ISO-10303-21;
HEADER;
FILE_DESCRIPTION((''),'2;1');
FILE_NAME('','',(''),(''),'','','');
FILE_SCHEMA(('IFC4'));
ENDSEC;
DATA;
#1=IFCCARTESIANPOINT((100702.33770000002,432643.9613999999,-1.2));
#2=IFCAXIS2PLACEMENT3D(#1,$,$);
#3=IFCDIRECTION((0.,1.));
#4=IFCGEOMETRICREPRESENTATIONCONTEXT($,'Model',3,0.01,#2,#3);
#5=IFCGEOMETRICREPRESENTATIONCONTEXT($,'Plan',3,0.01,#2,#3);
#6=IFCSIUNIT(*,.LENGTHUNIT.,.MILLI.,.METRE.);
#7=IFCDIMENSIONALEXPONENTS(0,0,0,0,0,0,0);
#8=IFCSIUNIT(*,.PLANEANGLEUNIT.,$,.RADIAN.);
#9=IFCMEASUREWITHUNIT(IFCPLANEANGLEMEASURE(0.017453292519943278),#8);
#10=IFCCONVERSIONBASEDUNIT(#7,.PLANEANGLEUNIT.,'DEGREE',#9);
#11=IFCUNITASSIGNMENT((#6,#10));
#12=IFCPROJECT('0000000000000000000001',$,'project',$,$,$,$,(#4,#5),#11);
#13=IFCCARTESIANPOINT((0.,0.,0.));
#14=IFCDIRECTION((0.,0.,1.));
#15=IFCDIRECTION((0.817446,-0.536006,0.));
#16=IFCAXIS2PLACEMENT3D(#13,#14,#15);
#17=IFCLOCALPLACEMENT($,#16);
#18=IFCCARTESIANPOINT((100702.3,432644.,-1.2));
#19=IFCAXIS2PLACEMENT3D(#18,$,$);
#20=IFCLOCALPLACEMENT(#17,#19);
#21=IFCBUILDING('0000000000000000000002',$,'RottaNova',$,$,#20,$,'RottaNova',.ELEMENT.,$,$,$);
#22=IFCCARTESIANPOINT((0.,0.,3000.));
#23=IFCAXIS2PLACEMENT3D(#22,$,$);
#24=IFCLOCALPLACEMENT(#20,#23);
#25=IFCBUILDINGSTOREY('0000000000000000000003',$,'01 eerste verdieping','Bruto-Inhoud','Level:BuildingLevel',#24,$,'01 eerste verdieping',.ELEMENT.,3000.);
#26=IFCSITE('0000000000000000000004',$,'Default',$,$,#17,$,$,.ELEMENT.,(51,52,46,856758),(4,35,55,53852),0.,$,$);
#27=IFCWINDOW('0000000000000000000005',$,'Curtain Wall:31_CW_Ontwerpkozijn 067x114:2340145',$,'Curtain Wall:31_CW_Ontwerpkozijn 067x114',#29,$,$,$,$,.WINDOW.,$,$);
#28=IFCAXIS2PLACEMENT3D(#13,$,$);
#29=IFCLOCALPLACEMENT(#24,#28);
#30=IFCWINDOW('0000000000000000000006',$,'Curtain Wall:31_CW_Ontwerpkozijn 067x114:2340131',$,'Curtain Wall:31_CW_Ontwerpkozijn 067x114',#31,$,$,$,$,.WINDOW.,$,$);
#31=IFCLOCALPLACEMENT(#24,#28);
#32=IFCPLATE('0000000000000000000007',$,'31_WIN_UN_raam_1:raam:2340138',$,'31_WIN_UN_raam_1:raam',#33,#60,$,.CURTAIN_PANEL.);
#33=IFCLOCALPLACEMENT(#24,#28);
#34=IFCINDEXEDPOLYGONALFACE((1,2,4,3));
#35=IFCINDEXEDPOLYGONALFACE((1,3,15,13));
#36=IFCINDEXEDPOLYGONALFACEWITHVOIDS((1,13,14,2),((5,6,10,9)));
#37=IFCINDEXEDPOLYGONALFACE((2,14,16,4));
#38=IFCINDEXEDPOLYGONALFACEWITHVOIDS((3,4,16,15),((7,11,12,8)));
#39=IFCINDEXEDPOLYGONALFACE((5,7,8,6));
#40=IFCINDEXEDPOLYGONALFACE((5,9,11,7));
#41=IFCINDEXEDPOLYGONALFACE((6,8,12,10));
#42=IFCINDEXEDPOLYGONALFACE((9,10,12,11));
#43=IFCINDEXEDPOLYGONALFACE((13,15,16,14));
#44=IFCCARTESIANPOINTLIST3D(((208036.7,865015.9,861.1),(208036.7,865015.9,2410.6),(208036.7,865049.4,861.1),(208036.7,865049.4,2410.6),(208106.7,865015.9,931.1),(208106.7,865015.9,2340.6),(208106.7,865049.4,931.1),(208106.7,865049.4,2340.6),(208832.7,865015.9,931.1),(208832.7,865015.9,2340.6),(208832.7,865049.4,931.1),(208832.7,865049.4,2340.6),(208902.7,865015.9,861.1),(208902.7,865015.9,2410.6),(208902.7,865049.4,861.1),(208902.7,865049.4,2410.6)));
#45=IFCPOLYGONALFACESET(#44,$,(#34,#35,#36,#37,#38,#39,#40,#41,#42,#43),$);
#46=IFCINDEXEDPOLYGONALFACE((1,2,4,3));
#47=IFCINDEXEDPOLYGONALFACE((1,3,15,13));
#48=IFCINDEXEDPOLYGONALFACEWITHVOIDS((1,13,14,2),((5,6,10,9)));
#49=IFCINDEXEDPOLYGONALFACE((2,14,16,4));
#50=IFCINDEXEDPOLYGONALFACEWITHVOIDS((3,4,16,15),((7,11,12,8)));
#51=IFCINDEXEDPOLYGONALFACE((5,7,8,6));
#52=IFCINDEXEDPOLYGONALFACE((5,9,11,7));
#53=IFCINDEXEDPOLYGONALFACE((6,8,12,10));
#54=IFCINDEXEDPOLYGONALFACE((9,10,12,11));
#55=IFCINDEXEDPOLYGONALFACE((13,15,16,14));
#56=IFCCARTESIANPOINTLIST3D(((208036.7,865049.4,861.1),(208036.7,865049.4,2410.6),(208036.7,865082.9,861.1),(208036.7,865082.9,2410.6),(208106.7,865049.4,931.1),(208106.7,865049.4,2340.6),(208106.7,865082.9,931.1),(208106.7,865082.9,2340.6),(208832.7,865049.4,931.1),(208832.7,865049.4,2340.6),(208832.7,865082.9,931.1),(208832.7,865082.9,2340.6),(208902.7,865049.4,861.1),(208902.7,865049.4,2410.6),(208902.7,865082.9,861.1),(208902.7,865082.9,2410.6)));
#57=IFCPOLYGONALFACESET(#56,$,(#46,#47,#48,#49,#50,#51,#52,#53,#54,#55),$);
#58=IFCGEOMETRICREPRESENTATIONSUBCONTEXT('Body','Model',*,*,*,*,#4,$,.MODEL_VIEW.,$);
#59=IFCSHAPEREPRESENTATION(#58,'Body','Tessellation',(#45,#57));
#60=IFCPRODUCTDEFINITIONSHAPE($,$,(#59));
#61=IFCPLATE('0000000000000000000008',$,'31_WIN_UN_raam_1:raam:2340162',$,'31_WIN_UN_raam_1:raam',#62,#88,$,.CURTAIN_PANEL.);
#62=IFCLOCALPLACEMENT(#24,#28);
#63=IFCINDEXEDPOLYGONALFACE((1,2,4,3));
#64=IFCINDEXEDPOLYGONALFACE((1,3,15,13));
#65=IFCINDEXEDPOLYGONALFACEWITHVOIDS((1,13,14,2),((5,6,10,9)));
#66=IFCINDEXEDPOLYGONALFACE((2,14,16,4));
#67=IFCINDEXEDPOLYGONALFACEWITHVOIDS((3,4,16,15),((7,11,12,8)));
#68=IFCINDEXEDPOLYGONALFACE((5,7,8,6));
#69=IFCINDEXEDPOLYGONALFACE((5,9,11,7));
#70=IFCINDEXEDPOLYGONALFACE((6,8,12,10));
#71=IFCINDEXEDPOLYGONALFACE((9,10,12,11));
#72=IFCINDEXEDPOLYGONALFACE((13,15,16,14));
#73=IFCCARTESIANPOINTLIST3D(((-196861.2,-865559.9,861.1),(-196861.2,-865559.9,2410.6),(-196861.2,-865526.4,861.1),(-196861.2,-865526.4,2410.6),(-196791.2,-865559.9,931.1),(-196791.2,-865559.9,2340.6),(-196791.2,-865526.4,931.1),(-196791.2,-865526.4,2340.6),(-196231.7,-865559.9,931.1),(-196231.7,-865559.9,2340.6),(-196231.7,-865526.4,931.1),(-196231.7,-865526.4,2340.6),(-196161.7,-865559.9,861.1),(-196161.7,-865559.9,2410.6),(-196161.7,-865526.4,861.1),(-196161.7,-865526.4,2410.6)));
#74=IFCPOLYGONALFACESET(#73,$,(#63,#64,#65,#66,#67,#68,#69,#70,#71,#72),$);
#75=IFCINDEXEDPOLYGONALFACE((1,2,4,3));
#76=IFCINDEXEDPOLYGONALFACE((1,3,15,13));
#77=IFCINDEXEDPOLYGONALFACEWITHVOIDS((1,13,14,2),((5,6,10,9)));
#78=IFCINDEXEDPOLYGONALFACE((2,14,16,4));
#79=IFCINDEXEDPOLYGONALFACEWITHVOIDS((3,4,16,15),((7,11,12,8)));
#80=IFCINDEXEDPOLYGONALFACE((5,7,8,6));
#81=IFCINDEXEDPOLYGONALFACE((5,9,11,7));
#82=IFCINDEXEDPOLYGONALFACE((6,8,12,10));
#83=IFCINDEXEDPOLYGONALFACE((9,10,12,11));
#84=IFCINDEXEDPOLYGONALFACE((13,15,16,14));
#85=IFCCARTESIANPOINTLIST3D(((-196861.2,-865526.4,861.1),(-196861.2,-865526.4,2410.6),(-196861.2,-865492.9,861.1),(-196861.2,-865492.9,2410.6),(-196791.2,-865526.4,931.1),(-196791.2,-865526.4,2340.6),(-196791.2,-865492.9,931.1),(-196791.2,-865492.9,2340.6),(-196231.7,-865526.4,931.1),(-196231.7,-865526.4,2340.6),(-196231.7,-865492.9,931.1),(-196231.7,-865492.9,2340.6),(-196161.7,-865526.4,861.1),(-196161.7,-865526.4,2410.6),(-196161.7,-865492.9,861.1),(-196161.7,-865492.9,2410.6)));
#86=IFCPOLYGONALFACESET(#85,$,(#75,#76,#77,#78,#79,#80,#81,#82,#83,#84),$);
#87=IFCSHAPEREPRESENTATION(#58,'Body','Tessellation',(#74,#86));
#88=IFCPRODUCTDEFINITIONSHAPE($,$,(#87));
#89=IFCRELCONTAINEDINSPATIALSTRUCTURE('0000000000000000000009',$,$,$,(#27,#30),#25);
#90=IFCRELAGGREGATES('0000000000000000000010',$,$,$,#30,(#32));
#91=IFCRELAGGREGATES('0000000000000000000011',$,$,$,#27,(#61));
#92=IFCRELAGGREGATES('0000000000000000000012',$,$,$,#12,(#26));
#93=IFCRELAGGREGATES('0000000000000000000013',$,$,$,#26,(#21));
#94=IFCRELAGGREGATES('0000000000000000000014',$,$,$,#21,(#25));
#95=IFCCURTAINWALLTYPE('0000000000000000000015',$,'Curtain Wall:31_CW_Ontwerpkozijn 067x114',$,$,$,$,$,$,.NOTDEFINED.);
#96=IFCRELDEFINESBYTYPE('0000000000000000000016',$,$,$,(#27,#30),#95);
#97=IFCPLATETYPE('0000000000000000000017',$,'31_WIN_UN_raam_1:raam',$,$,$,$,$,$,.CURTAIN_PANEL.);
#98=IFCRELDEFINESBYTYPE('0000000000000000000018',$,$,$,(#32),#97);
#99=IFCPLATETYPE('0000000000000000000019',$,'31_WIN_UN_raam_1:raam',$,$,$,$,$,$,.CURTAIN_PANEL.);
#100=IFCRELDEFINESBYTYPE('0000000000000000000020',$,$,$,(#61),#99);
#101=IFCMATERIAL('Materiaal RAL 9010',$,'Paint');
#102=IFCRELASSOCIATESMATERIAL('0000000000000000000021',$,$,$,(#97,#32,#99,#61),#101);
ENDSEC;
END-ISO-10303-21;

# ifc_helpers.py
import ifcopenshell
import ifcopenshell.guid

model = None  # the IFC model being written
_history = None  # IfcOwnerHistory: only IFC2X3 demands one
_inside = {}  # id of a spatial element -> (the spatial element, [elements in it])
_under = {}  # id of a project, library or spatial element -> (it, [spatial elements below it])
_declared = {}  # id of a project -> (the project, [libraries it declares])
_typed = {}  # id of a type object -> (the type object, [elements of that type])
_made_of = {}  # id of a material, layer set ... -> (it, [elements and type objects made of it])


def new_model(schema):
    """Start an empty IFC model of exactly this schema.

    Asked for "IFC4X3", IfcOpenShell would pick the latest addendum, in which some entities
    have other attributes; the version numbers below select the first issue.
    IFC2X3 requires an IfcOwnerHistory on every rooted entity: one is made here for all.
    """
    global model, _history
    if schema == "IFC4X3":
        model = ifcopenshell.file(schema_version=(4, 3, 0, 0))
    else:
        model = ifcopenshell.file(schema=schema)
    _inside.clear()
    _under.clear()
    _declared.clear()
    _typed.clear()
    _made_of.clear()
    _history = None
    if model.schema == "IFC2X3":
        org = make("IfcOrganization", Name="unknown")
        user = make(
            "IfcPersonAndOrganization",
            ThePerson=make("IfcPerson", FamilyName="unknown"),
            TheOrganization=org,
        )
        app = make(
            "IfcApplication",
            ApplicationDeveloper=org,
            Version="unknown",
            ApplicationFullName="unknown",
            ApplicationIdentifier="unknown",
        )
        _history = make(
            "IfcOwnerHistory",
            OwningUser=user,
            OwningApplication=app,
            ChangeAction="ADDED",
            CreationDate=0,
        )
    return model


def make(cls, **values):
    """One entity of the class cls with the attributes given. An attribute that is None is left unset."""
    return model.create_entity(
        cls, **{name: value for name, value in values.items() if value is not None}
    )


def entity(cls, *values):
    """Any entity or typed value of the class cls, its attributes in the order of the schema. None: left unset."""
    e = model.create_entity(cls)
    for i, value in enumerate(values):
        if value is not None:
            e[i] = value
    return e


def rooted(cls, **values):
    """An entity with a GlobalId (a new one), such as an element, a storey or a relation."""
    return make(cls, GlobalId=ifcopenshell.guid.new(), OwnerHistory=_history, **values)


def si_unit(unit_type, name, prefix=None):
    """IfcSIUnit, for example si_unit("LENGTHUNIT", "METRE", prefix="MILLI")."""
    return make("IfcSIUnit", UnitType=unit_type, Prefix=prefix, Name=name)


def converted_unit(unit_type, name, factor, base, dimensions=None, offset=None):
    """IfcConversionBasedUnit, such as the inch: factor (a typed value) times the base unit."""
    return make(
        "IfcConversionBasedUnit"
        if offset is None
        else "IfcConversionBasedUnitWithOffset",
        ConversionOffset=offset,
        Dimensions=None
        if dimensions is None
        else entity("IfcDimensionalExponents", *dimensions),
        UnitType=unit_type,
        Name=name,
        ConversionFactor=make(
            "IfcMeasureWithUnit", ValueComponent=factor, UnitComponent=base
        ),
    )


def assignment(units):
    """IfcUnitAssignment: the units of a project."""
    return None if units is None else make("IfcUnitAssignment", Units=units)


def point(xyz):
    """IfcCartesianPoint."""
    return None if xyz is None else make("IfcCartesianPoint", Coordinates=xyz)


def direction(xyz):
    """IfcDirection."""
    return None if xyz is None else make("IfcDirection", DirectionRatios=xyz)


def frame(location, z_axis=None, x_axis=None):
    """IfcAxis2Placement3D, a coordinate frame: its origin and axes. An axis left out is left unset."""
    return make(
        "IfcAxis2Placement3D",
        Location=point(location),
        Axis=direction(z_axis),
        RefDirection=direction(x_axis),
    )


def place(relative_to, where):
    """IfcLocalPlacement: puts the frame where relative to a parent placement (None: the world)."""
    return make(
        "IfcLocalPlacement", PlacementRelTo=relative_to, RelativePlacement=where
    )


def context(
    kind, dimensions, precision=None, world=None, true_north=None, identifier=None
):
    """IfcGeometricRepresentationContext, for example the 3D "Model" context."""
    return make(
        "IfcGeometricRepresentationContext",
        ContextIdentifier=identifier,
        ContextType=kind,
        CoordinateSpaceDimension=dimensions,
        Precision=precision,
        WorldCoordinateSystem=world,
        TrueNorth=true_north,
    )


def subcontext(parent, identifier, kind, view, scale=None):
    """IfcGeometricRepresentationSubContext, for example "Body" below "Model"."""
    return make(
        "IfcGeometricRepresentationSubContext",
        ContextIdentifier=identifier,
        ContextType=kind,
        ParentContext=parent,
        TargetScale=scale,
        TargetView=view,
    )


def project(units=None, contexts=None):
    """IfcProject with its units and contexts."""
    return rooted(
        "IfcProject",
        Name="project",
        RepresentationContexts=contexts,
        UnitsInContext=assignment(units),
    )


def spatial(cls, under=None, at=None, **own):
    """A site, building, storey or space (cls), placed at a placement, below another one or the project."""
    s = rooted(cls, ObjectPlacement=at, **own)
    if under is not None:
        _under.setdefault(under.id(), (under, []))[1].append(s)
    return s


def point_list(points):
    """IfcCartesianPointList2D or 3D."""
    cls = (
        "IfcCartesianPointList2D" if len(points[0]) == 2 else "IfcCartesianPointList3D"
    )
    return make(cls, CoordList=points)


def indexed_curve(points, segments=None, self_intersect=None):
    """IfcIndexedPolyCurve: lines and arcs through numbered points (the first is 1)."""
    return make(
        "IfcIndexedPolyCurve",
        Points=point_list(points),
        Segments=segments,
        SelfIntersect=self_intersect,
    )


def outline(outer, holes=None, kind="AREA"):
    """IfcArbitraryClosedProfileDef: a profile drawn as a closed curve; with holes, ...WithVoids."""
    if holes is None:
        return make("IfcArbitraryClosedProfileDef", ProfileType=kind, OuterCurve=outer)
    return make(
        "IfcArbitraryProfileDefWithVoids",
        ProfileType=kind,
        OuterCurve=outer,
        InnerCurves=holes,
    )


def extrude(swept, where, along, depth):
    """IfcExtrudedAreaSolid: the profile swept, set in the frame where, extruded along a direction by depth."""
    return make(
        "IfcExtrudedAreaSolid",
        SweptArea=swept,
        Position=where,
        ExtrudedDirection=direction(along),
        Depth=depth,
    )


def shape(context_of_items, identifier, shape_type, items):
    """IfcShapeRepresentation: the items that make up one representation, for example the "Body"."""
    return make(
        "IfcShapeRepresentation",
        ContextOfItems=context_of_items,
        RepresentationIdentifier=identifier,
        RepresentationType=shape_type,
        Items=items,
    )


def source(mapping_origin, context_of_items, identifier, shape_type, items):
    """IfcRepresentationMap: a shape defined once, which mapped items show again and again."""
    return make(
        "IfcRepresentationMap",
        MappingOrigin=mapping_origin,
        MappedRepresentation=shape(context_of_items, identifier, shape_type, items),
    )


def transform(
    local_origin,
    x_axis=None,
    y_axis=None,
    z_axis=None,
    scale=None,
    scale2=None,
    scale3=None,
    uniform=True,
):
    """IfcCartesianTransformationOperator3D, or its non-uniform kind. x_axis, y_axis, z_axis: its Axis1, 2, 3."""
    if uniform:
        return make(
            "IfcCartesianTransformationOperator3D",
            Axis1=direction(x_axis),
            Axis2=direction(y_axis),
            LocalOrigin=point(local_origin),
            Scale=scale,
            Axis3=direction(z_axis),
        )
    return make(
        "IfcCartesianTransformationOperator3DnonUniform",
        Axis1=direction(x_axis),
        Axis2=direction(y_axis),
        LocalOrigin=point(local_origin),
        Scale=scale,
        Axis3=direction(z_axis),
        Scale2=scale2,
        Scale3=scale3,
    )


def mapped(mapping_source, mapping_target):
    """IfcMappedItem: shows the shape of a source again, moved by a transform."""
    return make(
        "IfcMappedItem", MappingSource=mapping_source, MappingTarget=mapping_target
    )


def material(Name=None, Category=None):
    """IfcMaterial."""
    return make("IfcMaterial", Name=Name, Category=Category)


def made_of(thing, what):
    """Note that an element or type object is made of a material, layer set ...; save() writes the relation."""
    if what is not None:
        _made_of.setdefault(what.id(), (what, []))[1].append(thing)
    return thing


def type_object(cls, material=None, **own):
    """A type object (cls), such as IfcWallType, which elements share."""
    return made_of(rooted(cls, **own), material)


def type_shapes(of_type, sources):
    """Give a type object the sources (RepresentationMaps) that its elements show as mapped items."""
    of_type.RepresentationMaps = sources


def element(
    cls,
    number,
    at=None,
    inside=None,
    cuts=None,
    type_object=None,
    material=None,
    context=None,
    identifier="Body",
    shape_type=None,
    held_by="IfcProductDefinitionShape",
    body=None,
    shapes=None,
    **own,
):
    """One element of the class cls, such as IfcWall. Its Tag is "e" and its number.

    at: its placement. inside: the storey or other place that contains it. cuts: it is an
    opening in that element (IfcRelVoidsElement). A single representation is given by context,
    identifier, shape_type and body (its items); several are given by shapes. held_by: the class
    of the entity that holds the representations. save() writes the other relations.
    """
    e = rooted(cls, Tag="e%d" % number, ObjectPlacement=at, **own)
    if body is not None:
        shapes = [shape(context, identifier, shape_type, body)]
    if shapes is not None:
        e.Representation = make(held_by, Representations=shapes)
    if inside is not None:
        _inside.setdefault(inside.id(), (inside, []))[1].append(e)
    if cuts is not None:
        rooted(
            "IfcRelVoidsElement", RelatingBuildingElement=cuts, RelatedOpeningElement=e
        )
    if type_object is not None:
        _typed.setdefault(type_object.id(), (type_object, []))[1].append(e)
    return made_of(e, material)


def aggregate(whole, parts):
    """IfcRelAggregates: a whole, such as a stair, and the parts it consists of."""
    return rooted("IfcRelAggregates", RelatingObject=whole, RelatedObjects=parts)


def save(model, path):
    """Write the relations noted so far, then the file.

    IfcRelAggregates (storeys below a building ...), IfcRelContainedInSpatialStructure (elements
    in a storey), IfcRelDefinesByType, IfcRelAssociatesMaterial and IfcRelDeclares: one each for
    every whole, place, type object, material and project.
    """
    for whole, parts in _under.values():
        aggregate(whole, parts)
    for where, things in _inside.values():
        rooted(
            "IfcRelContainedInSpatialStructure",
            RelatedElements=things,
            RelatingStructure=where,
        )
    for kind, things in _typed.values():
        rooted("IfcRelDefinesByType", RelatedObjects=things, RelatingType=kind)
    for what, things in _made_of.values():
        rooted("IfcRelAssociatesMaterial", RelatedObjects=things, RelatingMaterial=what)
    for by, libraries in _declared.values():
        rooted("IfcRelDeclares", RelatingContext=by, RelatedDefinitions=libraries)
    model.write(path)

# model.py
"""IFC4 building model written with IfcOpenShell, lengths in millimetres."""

from ifc_helpers import new_model, entity, si_unit, converted_unit, direction, frame, place, context, subcontext, project, spatial, indexed_curve, outline, extrude, source, transform, mapped, material, type_object, type_shapes, element, aggregate, save


model = new_model("IFC4")

# Units and contexts
model_context = context("Model", 3, precision=0.01, world=frame((100702.33770000002, 432643.9613999999, -1.2)), true_north=direction((0.0, 1.0)))
plan_context = context("Plan", 3, precision=0.01, world=frame((100702.33770000002, 432643.9613999999, -1.2)), true_north=direction((0.0, 1.0)))
body_context = subcontext(model_context, "Body", "Model", "MODEL_VIEW")
ifc_project = project(units=[si_unit("LENGTHUNIT", "METRE", prefix="MILLI"), converted_unit("PLANEANGLEUNIT", "DEGREE", entity("IfcPlaneAngleMeasure", 0.017453292519943278), si_unit("PLANEANGLEUNIT", "RADIAN"), dimensions=[0, 0, 0, 0, 0, 0, 0])], contexts=[model_context, plan_context])

# Site, building, storey
site_placement = place(None, frame((0.0, 0.0, 0.0), z_axis=(0.0, 0.0, 1.0), x_axis=(0.817446, -0.536006, 0.0)))
site = spatial("IfcSite", under=ifc_project, at=site_placement, Name="Default", CompositionType="ELEMENT", RefLatitude=(51, 52, 46, 856758), RefLongitude=(4, 35, 55, 53852), RefElevation=0.0)
building_placement = place(site_placement, frame((100702.3, 432644.0, -1.2)))
building = spatial("IfcBuilding", under=site, at=building_placement, Name="RottaNova", LongName="RottaNova", CompositionType="ELEMENT")
storey_placement = place(building_placement, frame((0.0, 0.0, 3000.0)))
storey = spatial("IfcBuildingStorey", under=building, at=storey_placement, Name="01 eerste verdieping", Description="Bruto-Inhoud", ObjectType="Level:BuildingLevel", LongName="01 eerste verdieping", CompositionType="ELEMENT", Elevation=3000.0)

# Shared definitions
curtain_wall_type = type_object("IfcCurtainWallType", Name="Curtain Wall:31_CW_Ontwerpkozijn 067x114", PredefinedType="NOTDEFINED")

# Windows
window_1_placement = place(storey_placement, frame((0.0, 0.0, -3000.0)))
window_1 = element("IfcWindow", 1, at=window_1_placement, inside=storey, type_object=curtain_wall_type, Name="Curtain Wall:31_CW_Ontwerpkozijn 067x114:2340145", ObjectType="Curtain Wall:31_CW_Ontwerpkozijn 067x114", PredefinedType="WINDOW")
window_2_placement = place(storey_placement, frame((0.0, 0.0, -3000.0)))
window_2 = element("IfcWindow", 2, at=window_2_placement, inside=storey, type_object=curtain_wall_type, Name="Curtain Wall:31_CW_Ontwerpkozijn 067x114:2340131", ObjectType="Curtain Wall:31_CW_Ontwerpkozijn 067x114", PredefinedType="WINDOW")

# Plates
ifc_material_1 = material(Name="Materiaal RAL 9010", Category="Paint")
plate_type_1 = type_object("IfcPlateType", Name="31_WIN_UN_raam_1:raam", PredefinedType="CURTAIN_PANEL", material=ifc_material_1)
shared_shape_1 = source(frame((100702.3, 432644.0, -1.2)), body_context, "Body", "SweptSolid", [
    extrude(outline(indexed_curve([(-433.0, -774.7), (433.0, -774.7), (433.0, 774.7), (-433.0, 774.7), (-433.0, -774.7)], self_intersect=False), holes=[indexed_curve([(-363.0, 704.7), (363.0, 704.7), (363.0, -704.8), (-363.0, -704.8), (-363.0, 704.7)], self_intersect=False)]), frame((0.0, -92.0, 774.8), z_axis=(0.0, 1.0, 0.0), x_axis=(1.0, 0.0, 0.0)), (0.0, 0.0, 1.0), 33.5),
    extrude(outline(indexed_curve([(-433.0, -774.7), (433.0, -774.7), (433.0, 774.7), (-433.0, 774.7), (-433.0, -774.7)], self_intersect=False), holes=[indexed_curve([(-363.0, 704.7), (363.0, 704.7), (363.0, -704.8), (-363.0, -704.8), (-363.0, 704.7)], self_intersect=False)]), frame((0.0, -58.5, 774.8), z_axis=(0.0, 1.0, 0.0), x_axis=(1.0, 0.0, 0.0)), (0.0, 0.0, 1.0), 33.5),
])
type_shapes(plate_type_1, [shared_shape_1])
plate_1_placement = place(window_2_placement, frame((7065.0, -180.0, 3863.5)))
plate_1 = element("IfcPlate", 3, at=plate_1_placement, type_object=plate_type_1, material=ifc_material_1, Name="31_WIN_UN_raam_1:raam:2340138", ObjectType="31_WIN_UN_raam_1:raam", PredefinedType="CURTAIN_PANEL", context=body_context, shape_type="MappedRepresentation", body=[
    mapped(shared_shape_1, transform((100702.3, 432644.0, -1.2), scale=1.0)),
])
aggregate(window_2, [plate_1])
plate_type_2 = type_object("IfcPlateType", Name="31_WIN_UN_raam_1:raam", PredefinedType="CURTAIN_PANEL", material=ifc_material_1)
shared_shape_2 = source(frame((100702.3, 432644.0, -1.2)), body_context, "Body", "SweptSolid", [
    extrude(outline(indexed_curve([(-349.7, -774.8), (349.7, -774.8), (349.7, 774.8), (-349.7, 774.8), (-349.7, -774.8)], self_intersect=False), holes=[indexed_curve([(-279.7, 704.8), (279.7, 704.8), (279.7, -704.8), (-279.7, -704.8), (-279.7, 704.8)], self_intersect=False)]), frame((0.0, 58.5, 774.8), z_axis=(0.0, 1.0, 0.0), x_axis=(1.0, 0.0, 0.0)), (0.0, 0.0, 1.0), 33.5),
    extrude(outline(indexed_curve([(-349.7, -774.8), (349.7, -774.8), (349.7, 774.8), (-349.7, 774.8), (-349.7, -774.8)], self_intersect=False), holes=[indexed_curve([(-279.7, 704.7), (279.7, 704.7), (279.7, -704.8), (-279.7, -704.8), (-279.7, 704.7)], self_intersect=False)]), frame((0.0, 25.0, 774.8), z_axis=(0.0, 1.0, 0.0), x_axis=(1.0, 0.0, 0.0)), (0.0, 0.0, 1.0), 33.5),
])
type_shapes(plate_type_2, [shared_shape_2])
plate_2_placement = place(window_1_placement, frame((4893.2, -180.0, 3863.5), z_axis=(0.0, 0.0, 1.0), x_axis=(-1.0, 0.0, 0.0)))
plate_2 = element("IfcPlate", 4, at=plate_2_placement, type_object=plate_type_2, material=ifc_material_1, Name="31_WIN_UN_raam_1:raam:2340162", ObjectType="31_WIN_UN_raam_1:raam", PredefinedType="CURTAIN_PANEL", context=body_context, shape_type="MappedRepresentation", body=[
    mapped(shared_shape_2, transform((100702.3, 432644.0, -1.2), scale=1.0)),
])
aggregate(window_1, [plate_2])

save(model, "model.ifc")
